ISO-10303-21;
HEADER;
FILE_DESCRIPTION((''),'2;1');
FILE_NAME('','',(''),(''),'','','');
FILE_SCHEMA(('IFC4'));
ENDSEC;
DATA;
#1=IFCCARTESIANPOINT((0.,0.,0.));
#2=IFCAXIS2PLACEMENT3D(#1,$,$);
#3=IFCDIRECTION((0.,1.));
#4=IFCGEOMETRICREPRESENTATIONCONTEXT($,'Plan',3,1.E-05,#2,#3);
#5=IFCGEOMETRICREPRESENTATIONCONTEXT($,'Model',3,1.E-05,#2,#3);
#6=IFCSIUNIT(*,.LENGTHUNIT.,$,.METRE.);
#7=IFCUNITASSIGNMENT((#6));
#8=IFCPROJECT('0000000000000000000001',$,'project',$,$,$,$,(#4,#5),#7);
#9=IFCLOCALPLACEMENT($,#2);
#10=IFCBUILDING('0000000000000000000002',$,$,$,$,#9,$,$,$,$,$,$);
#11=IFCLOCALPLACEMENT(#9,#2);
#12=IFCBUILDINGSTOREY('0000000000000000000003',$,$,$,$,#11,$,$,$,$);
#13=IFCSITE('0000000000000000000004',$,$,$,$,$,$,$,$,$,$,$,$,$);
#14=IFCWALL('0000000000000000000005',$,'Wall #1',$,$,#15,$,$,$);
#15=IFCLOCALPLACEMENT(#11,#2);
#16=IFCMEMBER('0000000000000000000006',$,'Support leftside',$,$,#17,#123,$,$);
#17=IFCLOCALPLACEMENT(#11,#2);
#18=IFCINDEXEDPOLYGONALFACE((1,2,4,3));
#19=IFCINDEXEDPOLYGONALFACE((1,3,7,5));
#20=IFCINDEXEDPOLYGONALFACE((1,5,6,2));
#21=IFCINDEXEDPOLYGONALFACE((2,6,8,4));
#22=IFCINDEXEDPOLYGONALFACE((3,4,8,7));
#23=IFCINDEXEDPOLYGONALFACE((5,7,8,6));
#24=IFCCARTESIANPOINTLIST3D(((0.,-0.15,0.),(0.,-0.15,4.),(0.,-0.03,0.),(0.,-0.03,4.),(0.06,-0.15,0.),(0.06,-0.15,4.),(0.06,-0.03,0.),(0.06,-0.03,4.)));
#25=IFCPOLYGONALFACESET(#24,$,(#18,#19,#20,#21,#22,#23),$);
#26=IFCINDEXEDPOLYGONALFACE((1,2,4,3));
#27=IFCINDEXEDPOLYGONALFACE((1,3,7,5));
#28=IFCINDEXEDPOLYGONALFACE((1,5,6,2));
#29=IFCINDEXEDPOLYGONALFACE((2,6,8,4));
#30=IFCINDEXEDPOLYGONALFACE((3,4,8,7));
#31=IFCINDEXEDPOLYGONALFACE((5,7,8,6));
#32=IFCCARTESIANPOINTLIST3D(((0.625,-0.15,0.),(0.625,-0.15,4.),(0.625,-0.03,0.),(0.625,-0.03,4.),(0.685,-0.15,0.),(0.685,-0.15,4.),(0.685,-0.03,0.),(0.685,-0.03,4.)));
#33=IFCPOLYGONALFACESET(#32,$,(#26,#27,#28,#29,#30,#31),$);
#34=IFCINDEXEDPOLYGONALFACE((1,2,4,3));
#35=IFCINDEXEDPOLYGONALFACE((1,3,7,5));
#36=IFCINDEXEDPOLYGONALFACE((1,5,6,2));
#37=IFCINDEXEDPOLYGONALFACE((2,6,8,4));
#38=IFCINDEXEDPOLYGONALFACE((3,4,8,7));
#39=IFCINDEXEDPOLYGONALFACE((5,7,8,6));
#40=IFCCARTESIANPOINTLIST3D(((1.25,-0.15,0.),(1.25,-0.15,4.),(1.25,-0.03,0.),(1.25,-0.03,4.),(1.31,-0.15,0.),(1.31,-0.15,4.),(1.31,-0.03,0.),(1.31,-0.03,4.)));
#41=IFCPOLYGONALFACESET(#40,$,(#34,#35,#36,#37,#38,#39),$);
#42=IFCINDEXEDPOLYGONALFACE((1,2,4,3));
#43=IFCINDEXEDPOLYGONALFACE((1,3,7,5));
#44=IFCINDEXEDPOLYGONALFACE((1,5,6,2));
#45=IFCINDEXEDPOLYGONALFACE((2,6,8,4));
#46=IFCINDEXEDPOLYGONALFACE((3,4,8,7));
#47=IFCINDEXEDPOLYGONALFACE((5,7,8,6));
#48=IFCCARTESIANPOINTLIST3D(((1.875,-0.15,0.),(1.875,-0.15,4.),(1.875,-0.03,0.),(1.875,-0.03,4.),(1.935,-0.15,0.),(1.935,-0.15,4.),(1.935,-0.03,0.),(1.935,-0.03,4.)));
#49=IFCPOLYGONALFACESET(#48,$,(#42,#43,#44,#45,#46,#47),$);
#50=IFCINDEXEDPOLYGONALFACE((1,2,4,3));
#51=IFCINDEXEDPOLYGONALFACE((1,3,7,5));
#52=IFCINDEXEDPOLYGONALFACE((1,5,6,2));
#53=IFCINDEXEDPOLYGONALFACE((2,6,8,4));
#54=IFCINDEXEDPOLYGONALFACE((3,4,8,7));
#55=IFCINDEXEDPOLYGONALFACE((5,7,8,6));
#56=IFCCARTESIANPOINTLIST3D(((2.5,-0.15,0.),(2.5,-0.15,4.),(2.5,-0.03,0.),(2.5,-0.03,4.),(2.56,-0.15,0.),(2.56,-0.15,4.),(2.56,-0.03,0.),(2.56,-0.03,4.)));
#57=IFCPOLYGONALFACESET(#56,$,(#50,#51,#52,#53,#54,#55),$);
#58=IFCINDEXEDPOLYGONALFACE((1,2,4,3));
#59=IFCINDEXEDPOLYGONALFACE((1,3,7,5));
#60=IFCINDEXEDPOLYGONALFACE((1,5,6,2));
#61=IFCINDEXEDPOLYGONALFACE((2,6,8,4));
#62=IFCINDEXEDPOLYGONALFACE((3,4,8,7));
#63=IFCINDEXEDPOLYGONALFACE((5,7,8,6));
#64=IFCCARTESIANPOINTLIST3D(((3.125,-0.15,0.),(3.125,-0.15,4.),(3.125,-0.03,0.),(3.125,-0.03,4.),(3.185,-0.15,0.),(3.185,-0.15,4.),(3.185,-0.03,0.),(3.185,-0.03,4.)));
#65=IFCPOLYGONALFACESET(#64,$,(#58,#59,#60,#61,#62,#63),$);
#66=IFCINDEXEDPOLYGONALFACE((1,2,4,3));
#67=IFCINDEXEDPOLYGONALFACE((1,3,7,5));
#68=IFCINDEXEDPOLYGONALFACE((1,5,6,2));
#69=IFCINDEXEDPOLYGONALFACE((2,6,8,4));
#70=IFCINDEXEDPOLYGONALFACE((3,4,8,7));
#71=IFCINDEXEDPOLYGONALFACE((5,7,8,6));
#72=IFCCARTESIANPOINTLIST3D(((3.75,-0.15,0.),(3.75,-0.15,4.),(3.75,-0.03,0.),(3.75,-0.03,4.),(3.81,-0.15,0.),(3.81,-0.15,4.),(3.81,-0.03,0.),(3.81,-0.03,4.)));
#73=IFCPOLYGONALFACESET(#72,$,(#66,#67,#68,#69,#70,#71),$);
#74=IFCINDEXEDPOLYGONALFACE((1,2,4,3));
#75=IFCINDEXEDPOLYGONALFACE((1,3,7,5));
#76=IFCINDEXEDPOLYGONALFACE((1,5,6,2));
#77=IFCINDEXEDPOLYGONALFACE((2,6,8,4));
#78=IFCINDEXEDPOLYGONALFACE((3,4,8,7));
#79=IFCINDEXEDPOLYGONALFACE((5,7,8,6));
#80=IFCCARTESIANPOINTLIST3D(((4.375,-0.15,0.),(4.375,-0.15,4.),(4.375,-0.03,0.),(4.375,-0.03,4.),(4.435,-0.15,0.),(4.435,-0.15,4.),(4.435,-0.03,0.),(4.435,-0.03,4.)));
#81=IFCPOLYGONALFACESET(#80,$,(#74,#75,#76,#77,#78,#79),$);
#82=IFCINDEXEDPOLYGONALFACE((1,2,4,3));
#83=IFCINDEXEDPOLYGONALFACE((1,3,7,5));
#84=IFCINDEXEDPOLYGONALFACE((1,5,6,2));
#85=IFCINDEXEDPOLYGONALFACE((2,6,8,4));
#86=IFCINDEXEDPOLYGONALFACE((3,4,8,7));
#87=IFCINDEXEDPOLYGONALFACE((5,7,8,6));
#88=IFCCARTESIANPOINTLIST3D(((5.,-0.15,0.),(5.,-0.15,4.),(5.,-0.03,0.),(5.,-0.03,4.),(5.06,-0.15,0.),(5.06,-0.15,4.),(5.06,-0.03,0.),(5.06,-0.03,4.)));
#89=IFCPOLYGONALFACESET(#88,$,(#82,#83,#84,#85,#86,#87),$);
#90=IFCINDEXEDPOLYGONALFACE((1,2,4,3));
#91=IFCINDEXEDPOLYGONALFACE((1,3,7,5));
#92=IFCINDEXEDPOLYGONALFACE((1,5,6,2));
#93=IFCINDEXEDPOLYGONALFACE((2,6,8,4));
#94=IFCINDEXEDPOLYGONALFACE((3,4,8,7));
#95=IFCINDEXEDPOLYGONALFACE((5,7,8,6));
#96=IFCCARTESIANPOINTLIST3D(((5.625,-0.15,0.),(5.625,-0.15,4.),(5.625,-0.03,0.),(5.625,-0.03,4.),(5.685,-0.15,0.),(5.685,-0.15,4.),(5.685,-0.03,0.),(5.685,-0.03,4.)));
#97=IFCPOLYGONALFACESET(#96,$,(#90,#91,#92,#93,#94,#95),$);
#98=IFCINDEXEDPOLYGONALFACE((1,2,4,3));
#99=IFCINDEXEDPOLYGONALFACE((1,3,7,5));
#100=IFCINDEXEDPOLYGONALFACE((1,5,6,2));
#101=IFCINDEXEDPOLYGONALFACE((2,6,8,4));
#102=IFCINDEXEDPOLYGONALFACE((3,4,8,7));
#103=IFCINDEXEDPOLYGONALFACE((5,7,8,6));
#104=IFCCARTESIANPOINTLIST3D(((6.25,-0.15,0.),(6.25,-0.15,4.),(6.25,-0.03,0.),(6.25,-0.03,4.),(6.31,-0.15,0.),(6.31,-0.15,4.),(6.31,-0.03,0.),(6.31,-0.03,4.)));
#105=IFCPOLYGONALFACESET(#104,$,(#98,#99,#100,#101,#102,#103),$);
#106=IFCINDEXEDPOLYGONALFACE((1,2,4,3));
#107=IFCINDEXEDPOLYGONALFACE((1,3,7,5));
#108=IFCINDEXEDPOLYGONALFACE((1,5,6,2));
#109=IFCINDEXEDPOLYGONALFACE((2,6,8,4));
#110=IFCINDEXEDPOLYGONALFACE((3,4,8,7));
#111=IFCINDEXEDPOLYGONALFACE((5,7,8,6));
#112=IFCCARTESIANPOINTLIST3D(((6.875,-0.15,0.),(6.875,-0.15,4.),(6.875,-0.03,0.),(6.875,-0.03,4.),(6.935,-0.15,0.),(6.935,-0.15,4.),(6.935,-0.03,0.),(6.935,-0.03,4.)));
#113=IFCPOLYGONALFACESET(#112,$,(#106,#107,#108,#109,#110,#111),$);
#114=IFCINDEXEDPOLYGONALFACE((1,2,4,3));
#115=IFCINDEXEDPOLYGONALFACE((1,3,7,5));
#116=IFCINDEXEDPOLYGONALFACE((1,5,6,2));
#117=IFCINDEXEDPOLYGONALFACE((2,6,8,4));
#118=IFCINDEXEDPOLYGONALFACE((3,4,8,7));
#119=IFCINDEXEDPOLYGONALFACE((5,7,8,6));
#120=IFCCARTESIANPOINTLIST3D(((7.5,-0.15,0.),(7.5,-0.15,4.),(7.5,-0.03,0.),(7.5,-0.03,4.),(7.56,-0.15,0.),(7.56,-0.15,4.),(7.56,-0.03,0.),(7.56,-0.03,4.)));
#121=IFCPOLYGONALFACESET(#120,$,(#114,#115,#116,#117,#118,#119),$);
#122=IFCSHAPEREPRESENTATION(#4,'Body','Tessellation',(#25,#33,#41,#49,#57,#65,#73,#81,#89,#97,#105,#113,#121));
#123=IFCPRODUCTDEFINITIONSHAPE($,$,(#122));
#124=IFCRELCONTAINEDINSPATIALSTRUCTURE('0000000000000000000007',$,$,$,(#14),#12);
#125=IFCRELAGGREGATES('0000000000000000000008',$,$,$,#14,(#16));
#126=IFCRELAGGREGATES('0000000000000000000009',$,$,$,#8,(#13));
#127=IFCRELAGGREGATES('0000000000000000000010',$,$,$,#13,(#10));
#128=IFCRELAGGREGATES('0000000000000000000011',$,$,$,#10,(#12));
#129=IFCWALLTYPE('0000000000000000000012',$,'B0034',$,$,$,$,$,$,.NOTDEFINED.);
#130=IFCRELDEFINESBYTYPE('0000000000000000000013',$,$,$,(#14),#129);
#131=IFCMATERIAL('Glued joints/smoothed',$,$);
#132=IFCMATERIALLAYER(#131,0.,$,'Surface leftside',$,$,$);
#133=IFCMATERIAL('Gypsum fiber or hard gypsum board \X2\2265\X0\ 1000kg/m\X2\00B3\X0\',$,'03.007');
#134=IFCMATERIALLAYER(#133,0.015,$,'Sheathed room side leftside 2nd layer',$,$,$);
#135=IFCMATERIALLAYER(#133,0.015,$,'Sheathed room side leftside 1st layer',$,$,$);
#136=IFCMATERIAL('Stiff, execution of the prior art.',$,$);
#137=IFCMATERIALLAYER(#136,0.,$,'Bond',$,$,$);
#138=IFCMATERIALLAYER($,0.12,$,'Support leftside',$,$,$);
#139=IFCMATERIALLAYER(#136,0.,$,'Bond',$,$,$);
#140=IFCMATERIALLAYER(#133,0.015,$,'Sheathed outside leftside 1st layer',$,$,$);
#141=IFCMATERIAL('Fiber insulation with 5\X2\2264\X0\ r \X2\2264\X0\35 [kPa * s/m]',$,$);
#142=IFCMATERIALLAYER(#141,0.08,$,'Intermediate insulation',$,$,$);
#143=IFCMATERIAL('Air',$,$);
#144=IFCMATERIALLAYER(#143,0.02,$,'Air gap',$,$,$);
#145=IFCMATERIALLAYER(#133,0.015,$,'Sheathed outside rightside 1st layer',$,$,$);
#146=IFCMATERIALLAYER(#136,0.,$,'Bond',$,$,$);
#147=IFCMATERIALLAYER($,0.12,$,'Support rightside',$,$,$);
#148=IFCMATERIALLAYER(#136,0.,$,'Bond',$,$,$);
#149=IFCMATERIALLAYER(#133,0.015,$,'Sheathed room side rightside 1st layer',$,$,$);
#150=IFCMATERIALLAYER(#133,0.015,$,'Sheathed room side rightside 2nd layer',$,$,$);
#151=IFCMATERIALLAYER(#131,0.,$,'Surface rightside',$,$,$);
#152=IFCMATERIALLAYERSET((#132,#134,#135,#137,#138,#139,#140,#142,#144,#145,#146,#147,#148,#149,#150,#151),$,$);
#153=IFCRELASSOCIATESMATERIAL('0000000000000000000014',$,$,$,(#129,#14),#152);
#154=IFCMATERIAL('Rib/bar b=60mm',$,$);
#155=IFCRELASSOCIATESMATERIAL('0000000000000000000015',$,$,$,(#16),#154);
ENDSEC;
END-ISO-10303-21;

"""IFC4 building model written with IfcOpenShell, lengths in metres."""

from ifc_helpers import new_model, si_unit, direction, frame, frame_2d, origin, place, context, project, spatial, rectangle, extrude, material, layer, layer_set, type_object, element, aggregate, save


model = new_model("IFC4")

# Units and contexts
plan_context = context("Plan", 3, precision=1e-05, world=origin(), true_north=direction((0.0, 1.0)))
model_context = context("Model", 3, precision=1e-05, world=origin(), true_north=direction((0.0, 1.0)))
ifc_project = project(units=[si_unit("LENGTHUNIT", "METRE")], contexts=[plan_context, model_context])

# Site, building, storey
site = spatial("IfcSite", under=ifc_project)
building_placement = place(None, origin())
building = spatial("IfcBuilding", under=site, at=building_placement)
storey_placement = place(building_placement, origin())
storey = spatial("IfcBuildingStorey", under=building, at=storey_placement)

# Wall, member
ifc_material_1 = material(Name="Glued joints/smoothed")
ifc_layer_1 = layer(ifc_material_1, 0.0, Name="Surface leftside")
ifc_material_2 = material(Name="Gypsum fiber or hard gypsum board ≥ 1000kg/m³", Category="03.007")
ifc_layer_2 = layer(ifc_material_2, 0.015, Name="Sheathed room side leftside 2nd layer")
ifc_layer_3 = layer(ifc_material_2, 0.015, Name="Sheathed room side leftside 1st layer")
ifc_material_3 = material(Name="Stiff, execution of the prior art.")
ifc_layer_4 = layer(ifc_material_3, 0.0, Name="Bond")
ifc_layer_5 = layer(None, 0.12, Name="Support leftside")
ifc_layer_6 = layer(ifc_material_3, 0.0, Name="Bond")
ifc_layer_7 = layer(ifc_material_2, 0.015, Name="Sheathed outside leftside 1st layer")
ifc_material_4 = material(Name="Fiber insulation with 5≤ r ≤35 [kPa * s/m]")
ifc_layer_8 = layer(ifc_material_4, 0.08, Name="Intermediate insulation")
ifc_material_5 = material(Name="Air")
ifc_layer_9 = layer(ifc_material_5, 0.02, Name="Air gap")
ifc_layer_10 = layer(ifc_material_2, 0.015, Name="Sheathed outside rightside 1st layer")
ifc_layer_11 = layer(ifc_material_3, 0.0, Name="Bond")
ifc_layer_12 = layer(None, 0.12, Name="Support rightside")
ifc_layer_13 = layer(ifc_material_3, 0.0, Name="Bond")
ifc_layer_14 = layer(ifc_material_2, 0.015, Name="Sheathed room side rightside 1st layer")
ifc_layer_15 = layer(ifc_material_2, 0.015, Name="Sheathed room side rightside 2nd layer")
ifc_layer_16 = layer(ifc_material_1, 0.0, Name="Surface rightside")
ifc_layer_set = layer_set([ifc_layer_1, ifc_layer_2, ifc_layer_3, ifc_layer_4, ifc_layer_5, ifc_layer_6, ifc_layer_7, ifc_layer_8, ifc_layer_9, ifc_layer_10, ifc_layer_11, ifc_layer_12, ifc_layer_13, ifc_layer_14, ifc_layer_15, ifc_layer_16])
wall_type = type_object("IfcWallType", Name="B0034", PredefinedType="NOTDEFINED", material=ifc_layer_set)
wall_placement = place(None, frame((0.0, 0.0, 0.0), z_axis=(0.0, -1.0, 0.0), x_axis=(1.0, 0.0, 0.0)))
wall = element("IfcWall", 1, at=wall_placement, inside=storey, type_object=wall_type, material=ifc_layer_set, Name="Wall #1")
ifc_material_6 = material(Name="Rib/bar b=60mm")
member_1_placement = place(wall_placement, origin())
member_1 = element("IfcMember", 2, at=member_1_placement, material=ifc_material_6, Name="Support leftside", context=plan_context, shape_type="SweptSolid", body=[
    extrude(rectangle(XDim=0.06, YDim=0.12, at=frame_2d((0.03, 0.06), x_axis=(1.0, 0.0))), frame((0.0, 4.0, 0.03), z_axis=(0.0, -1.0, 0.0), x_axis=(1.0, 0.0, 0.0)), (0.0, 0.0, 1.0), 4.0),
    extrude(rectangle(XDim=0.06, YDim=0.12, at=frame_2d((0.03, 0.06), x_axis=(1.0, 0.0))), frame((0.625, 4.0, 0.03), z_axis=(0.0, -1.0, 0.0), x_axis=(1.0, 0.0, 0.0)), (0.0, 0.0, 1.0), 4.0),
    extrude(rectangle(XDim=0.06, YDim=0.12, at=frame_2d((0.03, 0.06), x_axis=(1.0, 0.0))), frame((1.25, 4.0, 0.03), z_axis=(0.0, -1.0, 0.0), x_axis=(1.0, 0.0, 0.0)), (0.0, 0.0, 1.0), 4.0),
    extrude(rectangle(XDim=0.06, YDim=0.12, at=frame_2d((0.03, 0.06), x_axis=(1.0, 0.0))), frame((1.875, 4.0, 0.03), z_axis=(0.0, -1.0, 0.0), x_axis=(1.0, 0.0, 0.0)), (0.0, 0.0, 1.0), 4.0),
    extrude(rectangle(XDim=0.06, YDim=0.12, at=frame_2d((0.03, 0.06), x_axis=(1.0, 0.0))), frame((2.5, 4.0, 0.03), z_axis=(0.0, -1.0, 0.0), x_axis=(1.0, 0.0, 0.0)), (0.0, 0.0, 1.0), 4.0),
    extrude(rectangle(XDim=0.06, YDim=0.12, at=frame_2d((0.03, 0.06), x_axis=(1.0, 0.0))), frame((3.125, 4.0, 0.03), z_axis=(0.0, -1.0, 0.0), x_axis=(1.0, 0.0, 0.0)), (0.0, 0.0, 1.0), 4.0),
    extrude(rectangle(XDim=0.06, YDim=0.12, at=frame_2d((0.03, 0.06), x_axis=(1.0, 0.0))), frame((3.75, 4.0, 0.03), z_axis=(0.0, -1.0, 0.0), x_axis=(1.0, 0.0, 0.0)), (0.0, 0.0, 1.0), 4.0),
    extrude(rectangle(XDim=0.06, YDim=0.12, at=frame_2d((0.03, 0.06), x_axis=(1.0, 0.0))), frame((4.375, 4.0, 0.03), z_axis=(0.0, -1.0, 0.0), x_axis=(1.0, 0.0, 0.0)), (0.0, 0.0, 1.0), 4.0),
    extrude(rectangle(XDim=0.06, YDim=0.12, at=frame_2d((0.03, 0.06), x_axis=(1.0, 0.0))), frame((5.0, 4.0, 0.03), z_axis=(0.0, -1.0, 0.0), x_axis=(1.0, 0.0, 0.0)), (0.0, 0.0, 1.0), 4.0),
    extrude(rectangle(XDim=0.06, YDim=0.12, at=frame_2d((0.03, 0.06), x_axis=(1.0, 0.0))), frame((5.625, 4.0, 0.03), z_axis=(0.0, -1.0, 0.0), x_axis=(1.0, 0.0, 0.0)), (0.0, 0.0, 1.0), 4.0),
    extrude(rectangle(XDim=0.06, YDim=0.12, at=frame_2d((0.03, 0.06), x_axis=(1.0, 0.0))), frame((6.25, 4.0, 0.03), z_axis=(0.0, -1.0, 0.0), x_axis=(1.0, 0.0, 0.0)), (0.0, 0.0, 1.0), 4.0),
    extrude(rectangle(XDim=0.06, YDim=0.12, at=frame_2d((0.03, 0.06), x_axis=(1.0, 0.0))), frame((6.875, 4.0, 0.03), z_axis=(0.0, -1.0, 0.0), x_axis=(1.0, 0.0, 0.0)), (0.0, 0.0, 1.0), 4.0),
    extrude(rectangle(XDim=0.06, YDim=0.12, at=frame_2d((0.03, 0.06), x_axis=(1.0, 0.0))), frame((7.5, 4.0, 0.03), z_axis=(0.0, -1.0, 0.0), x_axis=(1.0, 0.0, 0.0)), (0.0, 0.0, 1.0), 4.0),
])
aggregate(wall, [member_1])

save(model, "model.ifc")
